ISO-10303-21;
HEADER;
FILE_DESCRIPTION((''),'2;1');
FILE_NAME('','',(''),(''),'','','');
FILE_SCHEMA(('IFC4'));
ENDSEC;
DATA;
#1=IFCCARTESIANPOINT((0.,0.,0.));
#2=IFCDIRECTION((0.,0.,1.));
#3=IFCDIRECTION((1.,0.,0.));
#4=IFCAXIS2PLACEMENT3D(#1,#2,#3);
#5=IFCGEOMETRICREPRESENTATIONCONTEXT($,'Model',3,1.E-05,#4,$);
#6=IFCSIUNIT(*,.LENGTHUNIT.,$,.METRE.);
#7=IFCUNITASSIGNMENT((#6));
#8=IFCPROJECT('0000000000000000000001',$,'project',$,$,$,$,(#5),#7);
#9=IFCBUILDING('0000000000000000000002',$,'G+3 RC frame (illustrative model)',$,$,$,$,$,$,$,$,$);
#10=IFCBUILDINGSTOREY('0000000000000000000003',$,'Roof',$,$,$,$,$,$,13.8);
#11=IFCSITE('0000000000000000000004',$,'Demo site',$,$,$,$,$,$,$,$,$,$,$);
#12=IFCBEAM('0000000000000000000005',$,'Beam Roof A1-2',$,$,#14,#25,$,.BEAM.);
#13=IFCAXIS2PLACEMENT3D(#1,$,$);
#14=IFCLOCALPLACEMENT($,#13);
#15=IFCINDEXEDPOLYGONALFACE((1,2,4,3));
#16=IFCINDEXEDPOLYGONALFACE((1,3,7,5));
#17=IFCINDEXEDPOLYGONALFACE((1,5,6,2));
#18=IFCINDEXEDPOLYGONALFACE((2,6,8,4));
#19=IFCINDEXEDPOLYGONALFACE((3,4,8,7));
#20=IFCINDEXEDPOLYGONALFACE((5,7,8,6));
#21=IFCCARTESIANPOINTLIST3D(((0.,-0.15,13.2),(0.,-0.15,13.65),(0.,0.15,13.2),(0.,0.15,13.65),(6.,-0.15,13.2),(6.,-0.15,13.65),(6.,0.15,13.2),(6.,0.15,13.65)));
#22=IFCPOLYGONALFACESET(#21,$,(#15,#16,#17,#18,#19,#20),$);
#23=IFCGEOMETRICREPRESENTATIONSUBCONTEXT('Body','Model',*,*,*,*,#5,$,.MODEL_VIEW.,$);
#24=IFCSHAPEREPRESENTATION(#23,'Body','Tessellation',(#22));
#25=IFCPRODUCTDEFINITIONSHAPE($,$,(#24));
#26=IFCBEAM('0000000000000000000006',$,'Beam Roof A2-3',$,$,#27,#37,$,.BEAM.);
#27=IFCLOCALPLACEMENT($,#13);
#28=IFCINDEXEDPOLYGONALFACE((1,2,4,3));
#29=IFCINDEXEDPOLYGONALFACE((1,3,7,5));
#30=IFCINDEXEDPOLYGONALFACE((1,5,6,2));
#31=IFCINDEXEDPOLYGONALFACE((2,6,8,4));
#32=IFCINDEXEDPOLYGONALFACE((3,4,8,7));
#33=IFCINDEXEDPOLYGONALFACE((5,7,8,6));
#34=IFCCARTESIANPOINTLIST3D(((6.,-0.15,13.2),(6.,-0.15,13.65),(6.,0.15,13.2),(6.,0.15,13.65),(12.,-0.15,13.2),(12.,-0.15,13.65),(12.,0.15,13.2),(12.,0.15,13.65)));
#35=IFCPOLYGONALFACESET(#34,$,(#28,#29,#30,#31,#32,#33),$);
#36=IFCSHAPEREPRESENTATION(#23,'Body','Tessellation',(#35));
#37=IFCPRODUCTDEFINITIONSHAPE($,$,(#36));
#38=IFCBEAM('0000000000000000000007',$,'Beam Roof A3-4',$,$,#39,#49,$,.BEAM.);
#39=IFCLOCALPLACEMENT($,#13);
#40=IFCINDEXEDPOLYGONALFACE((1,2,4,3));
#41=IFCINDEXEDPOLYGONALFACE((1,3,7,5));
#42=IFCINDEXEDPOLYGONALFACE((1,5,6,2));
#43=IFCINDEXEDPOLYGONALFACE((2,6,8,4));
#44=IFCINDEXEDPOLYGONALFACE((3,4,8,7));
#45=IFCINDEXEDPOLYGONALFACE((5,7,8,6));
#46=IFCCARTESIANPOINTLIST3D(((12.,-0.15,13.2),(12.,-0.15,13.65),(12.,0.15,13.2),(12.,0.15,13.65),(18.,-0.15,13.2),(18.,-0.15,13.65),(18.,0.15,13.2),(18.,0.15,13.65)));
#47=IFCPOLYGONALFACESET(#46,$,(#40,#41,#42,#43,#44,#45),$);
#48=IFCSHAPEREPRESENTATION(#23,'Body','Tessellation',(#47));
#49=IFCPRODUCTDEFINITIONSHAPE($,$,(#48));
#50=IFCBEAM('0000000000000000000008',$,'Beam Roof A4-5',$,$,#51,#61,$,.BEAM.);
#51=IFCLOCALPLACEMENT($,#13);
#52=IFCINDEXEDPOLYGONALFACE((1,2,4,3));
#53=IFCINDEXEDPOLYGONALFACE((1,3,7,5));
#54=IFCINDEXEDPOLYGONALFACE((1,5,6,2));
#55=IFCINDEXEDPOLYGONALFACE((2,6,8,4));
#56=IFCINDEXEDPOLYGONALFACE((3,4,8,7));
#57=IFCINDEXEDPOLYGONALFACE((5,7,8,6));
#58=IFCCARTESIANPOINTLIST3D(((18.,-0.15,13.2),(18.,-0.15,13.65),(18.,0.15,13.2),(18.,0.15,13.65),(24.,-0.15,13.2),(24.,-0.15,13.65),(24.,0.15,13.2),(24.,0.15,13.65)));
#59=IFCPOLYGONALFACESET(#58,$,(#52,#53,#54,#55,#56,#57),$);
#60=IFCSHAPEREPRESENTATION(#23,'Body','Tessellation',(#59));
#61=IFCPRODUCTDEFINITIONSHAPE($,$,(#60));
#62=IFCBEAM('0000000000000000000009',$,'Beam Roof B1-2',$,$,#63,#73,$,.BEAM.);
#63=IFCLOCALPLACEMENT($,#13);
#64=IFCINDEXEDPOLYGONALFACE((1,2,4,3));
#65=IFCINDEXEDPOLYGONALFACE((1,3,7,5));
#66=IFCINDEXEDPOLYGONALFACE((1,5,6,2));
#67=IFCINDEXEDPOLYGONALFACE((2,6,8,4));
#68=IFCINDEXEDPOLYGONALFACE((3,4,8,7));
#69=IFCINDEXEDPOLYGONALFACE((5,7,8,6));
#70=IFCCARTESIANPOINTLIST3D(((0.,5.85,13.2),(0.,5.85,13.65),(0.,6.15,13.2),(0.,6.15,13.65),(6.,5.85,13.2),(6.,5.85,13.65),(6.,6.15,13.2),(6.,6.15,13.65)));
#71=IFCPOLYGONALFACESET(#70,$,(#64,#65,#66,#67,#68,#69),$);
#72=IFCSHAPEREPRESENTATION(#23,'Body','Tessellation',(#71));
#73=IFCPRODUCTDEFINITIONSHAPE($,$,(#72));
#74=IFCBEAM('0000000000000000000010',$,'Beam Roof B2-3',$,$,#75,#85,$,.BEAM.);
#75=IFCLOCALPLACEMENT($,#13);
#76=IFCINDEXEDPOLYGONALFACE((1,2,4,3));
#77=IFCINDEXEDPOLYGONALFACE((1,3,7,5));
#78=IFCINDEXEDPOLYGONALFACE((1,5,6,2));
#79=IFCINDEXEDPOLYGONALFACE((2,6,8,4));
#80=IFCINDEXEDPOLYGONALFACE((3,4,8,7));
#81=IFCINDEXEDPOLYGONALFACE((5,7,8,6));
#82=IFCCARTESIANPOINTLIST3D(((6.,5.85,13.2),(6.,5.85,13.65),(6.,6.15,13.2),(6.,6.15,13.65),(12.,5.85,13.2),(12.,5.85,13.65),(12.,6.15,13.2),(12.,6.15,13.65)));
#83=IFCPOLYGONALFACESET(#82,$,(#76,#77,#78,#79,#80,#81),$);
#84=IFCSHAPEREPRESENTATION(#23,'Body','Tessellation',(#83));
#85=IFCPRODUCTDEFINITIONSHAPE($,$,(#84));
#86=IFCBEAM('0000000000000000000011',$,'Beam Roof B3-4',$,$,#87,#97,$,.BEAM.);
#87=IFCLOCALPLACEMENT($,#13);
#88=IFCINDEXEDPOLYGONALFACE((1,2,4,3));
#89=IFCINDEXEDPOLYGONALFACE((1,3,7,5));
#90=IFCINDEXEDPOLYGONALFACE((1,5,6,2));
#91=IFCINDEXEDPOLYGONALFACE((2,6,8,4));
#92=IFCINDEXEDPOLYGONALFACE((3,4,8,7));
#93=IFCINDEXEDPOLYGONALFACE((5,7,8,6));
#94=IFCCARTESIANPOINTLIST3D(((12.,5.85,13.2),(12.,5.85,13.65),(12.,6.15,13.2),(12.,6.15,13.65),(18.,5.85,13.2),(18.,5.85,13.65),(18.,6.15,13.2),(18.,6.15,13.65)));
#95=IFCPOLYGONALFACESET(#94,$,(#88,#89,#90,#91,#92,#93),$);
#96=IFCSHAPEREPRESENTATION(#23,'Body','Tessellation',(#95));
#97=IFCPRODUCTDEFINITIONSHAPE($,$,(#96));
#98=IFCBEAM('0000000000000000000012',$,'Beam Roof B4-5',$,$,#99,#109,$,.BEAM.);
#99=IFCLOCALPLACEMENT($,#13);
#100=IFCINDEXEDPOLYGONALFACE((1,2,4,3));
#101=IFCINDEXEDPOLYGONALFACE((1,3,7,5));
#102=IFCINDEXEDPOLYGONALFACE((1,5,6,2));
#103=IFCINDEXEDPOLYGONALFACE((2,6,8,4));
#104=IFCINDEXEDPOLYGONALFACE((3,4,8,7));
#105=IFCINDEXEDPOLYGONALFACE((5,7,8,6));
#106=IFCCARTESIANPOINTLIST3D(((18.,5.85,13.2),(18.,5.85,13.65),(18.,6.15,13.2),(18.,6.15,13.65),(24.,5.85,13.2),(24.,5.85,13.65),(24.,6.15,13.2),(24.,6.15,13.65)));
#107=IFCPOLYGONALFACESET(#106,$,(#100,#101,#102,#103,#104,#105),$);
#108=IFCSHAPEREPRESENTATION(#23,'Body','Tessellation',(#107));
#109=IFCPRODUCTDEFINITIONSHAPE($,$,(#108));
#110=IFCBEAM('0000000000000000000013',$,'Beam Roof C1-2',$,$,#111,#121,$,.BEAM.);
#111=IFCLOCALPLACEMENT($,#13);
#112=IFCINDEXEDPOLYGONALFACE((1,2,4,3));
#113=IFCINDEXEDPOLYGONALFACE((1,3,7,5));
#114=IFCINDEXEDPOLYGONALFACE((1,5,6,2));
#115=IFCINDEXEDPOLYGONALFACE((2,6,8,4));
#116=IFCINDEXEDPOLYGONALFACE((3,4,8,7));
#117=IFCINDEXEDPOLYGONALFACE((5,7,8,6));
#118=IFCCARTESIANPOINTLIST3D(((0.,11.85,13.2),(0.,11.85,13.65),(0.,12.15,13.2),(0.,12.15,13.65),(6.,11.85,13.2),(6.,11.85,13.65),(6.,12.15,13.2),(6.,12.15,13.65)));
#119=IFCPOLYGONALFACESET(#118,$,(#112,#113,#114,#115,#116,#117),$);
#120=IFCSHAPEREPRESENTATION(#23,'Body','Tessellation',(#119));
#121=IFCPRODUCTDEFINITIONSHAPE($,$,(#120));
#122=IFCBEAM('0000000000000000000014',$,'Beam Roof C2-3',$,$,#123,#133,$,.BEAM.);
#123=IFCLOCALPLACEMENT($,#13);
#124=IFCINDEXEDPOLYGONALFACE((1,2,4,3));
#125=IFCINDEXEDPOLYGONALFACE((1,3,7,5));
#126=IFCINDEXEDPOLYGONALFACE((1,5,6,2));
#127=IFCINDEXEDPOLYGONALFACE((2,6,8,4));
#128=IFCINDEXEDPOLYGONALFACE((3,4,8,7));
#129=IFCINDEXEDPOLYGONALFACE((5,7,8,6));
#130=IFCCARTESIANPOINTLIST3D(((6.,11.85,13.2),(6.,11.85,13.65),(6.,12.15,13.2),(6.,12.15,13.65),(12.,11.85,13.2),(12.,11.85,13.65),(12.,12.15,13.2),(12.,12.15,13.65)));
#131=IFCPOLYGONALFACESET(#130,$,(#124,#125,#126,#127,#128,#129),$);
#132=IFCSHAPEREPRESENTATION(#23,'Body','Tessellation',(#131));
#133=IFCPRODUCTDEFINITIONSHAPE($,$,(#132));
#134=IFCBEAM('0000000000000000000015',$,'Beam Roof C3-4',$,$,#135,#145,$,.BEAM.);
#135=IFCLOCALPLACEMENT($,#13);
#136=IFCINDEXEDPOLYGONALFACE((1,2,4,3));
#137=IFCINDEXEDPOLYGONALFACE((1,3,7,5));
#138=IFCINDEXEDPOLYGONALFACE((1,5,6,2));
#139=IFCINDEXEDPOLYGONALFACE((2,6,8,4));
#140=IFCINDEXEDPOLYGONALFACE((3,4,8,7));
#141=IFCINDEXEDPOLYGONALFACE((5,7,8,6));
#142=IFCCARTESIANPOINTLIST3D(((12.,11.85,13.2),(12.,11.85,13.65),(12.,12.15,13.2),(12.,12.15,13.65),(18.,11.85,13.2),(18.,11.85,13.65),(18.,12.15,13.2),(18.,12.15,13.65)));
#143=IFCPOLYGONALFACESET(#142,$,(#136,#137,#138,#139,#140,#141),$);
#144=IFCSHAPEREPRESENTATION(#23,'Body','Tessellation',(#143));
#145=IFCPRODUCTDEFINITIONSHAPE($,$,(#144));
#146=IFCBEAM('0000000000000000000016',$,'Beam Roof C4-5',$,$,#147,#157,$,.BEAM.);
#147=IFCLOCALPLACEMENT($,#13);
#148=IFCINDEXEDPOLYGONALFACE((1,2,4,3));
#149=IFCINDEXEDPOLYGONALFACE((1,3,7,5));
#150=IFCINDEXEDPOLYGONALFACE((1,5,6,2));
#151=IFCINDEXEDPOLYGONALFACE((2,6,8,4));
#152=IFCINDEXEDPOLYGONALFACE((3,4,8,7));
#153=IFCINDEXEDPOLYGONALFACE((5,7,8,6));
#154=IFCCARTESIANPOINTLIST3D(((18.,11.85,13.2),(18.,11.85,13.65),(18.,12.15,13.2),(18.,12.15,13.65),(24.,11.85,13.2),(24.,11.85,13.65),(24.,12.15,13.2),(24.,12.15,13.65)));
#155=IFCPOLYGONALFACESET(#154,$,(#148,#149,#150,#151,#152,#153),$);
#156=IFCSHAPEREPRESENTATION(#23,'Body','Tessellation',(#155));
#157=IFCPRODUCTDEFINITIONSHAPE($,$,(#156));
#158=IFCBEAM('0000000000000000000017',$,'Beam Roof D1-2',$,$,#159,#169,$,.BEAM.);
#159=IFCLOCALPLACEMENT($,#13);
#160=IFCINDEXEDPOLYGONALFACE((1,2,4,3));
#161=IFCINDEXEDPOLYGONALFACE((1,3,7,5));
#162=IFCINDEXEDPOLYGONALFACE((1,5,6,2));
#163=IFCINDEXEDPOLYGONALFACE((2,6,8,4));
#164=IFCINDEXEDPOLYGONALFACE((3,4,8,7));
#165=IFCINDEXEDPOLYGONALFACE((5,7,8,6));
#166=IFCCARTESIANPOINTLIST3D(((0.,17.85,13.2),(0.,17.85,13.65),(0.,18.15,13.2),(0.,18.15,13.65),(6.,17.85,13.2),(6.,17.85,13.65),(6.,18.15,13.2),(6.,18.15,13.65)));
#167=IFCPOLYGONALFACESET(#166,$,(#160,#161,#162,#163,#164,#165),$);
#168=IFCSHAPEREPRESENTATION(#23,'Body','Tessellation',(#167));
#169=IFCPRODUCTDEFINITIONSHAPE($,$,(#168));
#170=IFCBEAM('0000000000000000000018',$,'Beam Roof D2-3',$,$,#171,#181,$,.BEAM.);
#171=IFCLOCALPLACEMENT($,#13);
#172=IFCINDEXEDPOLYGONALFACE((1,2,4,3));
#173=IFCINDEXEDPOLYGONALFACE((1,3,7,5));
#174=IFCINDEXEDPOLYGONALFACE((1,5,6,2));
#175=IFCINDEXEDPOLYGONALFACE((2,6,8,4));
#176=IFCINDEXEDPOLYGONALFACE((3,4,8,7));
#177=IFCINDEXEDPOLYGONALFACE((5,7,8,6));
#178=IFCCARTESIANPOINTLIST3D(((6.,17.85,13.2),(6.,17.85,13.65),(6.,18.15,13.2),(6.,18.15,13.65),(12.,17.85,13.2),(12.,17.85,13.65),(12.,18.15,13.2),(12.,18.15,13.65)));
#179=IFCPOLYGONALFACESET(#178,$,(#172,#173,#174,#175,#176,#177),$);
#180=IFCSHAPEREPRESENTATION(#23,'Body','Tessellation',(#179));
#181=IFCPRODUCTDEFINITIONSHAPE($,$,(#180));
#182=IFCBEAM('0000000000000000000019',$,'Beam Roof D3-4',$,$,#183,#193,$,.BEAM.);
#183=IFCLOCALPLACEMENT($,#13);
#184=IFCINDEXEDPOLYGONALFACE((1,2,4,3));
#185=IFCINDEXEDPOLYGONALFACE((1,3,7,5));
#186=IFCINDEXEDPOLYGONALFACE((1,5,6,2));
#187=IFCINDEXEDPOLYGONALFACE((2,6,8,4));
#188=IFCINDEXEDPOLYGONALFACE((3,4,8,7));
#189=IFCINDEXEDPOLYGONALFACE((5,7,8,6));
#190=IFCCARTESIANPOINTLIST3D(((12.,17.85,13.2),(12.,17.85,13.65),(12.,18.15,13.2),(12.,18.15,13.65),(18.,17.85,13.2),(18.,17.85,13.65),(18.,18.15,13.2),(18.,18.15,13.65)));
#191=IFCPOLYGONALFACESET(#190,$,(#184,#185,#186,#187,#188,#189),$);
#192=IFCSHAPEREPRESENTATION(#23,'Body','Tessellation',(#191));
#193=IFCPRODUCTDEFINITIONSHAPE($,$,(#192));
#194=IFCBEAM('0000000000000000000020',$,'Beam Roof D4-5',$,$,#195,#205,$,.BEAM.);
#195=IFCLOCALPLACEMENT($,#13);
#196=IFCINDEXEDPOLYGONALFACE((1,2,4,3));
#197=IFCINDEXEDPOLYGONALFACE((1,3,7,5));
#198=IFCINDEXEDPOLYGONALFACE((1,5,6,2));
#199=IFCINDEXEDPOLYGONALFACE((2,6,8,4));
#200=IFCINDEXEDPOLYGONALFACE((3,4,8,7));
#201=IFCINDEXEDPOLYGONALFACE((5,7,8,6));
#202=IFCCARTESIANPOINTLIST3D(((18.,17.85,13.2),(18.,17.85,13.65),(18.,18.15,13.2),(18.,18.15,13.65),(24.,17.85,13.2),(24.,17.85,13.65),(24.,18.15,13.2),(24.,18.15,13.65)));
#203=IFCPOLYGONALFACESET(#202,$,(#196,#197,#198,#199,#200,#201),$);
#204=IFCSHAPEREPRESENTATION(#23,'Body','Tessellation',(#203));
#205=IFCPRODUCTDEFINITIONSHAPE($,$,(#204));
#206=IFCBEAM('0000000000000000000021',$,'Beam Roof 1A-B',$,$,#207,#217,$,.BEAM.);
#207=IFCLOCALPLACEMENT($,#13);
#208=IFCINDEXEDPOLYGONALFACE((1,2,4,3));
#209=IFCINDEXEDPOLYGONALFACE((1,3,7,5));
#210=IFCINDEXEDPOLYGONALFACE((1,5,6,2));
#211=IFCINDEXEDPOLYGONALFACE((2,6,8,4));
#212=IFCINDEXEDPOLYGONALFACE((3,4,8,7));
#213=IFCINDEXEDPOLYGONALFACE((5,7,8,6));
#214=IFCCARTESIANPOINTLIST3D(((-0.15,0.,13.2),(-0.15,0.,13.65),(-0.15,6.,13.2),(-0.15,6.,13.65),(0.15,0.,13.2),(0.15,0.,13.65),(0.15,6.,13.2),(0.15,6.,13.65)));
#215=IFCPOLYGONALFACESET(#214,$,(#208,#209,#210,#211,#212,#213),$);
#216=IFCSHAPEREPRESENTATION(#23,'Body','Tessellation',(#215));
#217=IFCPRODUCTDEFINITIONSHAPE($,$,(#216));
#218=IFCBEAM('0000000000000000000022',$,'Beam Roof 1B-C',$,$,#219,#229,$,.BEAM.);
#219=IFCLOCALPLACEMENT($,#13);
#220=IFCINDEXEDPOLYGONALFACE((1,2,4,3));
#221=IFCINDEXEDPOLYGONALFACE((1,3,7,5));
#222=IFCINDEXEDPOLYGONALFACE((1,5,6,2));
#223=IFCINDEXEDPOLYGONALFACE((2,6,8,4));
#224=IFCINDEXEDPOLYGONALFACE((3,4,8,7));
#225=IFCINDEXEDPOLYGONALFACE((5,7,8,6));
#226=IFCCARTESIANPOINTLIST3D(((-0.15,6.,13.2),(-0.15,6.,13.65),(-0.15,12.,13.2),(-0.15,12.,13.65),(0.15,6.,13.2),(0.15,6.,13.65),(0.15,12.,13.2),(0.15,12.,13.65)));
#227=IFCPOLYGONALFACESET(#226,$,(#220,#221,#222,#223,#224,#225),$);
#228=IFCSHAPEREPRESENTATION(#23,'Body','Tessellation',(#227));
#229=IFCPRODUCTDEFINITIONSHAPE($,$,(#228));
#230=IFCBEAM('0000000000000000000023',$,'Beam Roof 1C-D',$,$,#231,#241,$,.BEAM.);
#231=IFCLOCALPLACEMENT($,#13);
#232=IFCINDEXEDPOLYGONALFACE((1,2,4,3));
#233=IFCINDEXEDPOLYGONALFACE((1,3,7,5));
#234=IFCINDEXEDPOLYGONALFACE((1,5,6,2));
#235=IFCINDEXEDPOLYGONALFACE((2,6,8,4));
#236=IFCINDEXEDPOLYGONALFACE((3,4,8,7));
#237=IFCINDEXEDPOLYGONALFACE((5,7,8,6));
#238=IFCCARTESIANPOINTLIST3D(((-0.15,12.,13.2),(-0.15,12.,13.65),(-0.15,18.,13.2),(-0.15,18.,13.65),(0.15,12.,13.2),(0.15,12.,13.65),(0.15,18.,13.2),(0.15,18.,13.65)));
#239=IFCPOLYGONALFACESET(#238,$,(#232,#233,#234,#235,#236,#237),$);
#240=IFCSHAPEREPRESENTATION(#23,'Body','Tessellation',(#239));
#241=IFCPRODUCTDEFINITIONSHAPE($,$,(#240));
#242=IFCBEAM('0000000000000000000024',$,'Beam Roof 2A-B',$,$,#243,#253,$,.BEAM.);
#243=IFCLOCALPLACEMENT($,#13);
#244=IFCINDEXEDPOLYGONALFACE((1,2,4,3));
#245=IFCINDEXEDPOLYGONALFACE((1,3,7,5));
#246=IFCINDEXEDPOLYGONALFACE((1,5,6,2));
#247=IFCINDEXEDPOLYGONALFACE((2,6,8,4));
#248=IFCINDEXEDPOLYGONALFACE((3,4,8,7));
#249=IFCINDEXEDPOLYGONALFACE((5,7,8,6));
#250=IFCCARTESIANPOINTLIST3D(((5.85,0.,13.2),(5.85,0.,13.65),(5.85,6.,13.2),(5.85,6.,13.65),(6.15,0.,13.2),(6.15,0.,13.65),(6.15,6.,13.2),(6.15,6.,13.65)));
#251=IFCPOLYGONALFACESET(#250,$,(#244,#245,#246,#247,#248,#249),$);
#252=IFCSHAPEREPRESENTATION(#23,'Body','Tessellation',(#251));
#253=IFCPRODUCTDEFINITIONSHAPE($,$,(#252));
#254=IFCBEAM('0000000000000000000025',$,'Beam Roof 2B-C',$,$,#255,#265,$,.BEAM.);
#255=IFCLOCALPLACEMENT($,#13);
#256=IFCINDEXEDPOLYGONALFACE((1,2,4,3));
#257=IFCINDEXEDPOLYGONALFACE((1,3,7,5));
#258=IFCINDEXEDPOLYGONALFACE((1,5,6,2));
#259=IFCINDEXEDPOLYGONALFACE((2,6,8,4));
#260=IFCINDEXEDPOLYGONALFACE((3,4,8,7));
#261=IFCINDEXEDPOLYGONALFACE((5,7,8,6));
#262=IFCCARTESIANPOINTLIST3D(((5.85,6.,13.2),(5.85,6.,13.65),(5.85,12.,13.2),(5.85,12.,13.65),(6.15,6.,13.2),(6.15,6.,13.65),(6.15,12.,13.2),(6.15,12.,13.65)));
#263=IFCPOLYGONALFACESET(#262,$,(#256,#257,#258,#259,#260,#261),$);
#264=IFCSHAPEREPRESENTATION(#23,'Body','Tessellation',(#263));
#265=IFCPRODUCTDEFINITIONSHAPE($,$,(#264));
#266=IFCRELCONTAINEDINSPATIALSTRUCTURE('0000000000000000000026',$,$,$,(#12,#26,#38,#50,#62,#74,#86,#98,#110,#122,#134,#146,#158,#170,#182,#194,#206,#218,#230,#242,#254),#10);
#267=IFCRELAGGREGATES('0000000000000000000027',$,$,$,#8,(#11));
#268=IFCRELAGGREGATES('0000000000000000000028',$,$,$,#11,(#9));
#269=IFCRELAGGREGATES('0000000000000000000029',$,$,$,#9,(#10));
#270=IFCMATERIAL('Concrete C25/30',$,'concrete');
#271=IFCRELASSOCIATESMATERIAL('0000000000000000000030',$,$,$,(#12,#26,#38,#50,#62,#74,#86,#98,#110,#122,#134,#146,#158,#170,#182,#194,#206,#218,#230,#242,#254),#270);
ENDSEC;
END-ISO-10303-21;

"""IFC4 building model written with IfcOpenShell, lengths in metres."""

from ifc_helpers import new_model, si_unit, frame, frame_2d, origin, origin_with_axes, place, context, subcontext, project, spatial, rectangle, extrude, material, element, save


model = new_model("IFC4")

# Units and contexts
model_context = context("Model", 3, precision=1e-05, world=origin_with_axes())
body_context = subcontext(model_context, "Body", "Model", "MODEL_VIEW")
ifc_project = project(units=[si_unit("LENGTHUNIT", "METRE")], contexts=[model_context])

# Site, building, storey
site = spatial("IfcSite", under=ifc_project, Name="Demo site")
building = spatial("IfcBuilding", under=site, Name="G+3 RC frame (illustrative model)")
storey = spatial("IfcBuildingStorey", under=building, Name="Roof", Elevation=13.8)

# Beams
ifc_material_1 = material(Name="Concrete C25/30", Category="concrete")
for number, where, z_axis, x_axis, name in (
    (1, (0.0, -0.15, 13.2), (0.0, 0.0, 1.0), (1.0, 0.0, 0.0), "Beam Roof A1-2"),
    (2, (6.0, -0.15, 13.2), (0.0, 0.0, 1.0), (1.0, 0.0, 0.0), "Beam Roof A2-3"),
    (3, (12.0, -0.15, 13.2), (0.0, 0.0, 1.0), (1.0, 0.0, 0.0), "Beam Roof A3-4"),
    (4, (18.0, -0.15, 13.2), (0.0, 0.0, 1.0), (1.0, 0.0, 0.0), "Beam Roof A4-5"),
    (5, (0.0, 5.85, 13.2), (0.0, 0.0, 1.0), (1.0, 0.0, 0.0), "Beam Roof B1-2"),
    (6, (6.0, 5.85, 13.2), (0.0, 0.0, 1.0), (1.0, 0.0, 0.0), "Beam Roof B2-3"),
    (7, (12.0, 5.85, 13.2), (0.0, 0.0, 1.0), (1.0, 0.0, 0.0), "Beam Roof B3-4"),
    (8, (18.0, 5.85, 13.2), (0.0, 0.0, 1.0), (1.0, 0.0, 0.0), "Beam Roof B4-5"),
    (9, (0.0, 11.85, 13.2), (0.0, 0.0, 1.0), (1.0, 0.0, 0.0), "Beam Roof C1-2"),
    (10, (6.0, 11.85, 13.2), (0.0, 0.0, 1.0), (1.0, 0.0, 0.0), "Beam Roof C2-3"),
    (11, (12.0, 11.85, 13.2), (0.0, 0.0, 1.0), (1.0, 0.0, 0.0), "Beam Roof C3-4"),
    (12, (18.0, 11.85, 13.2), (0.0, 0.0, 1.0), (1.0, 0.0, 0.0), "Beam Roof C4-5"),
    (13, (0.0, 17.85, 13.2), (0.0, 0.0, 1.0), (1.0, 0.0, 0.0), "Beam Roof D1-2"),
    (14, (6.0, 17.85, 13.2), (0.0, 0.0, 1.0), (1.0, 0.0, 0.0), "Beam Roof D2-3"),
    (15, (12.0, 17.85, 13.2), (0.0, 0.0, 1.0), (1.0, 0.0, 0.0), "Beam Roof D3-4"),
    (16, (18.0, 17.85, 13.2), (0.0, 0.0, 1.0), (1.0, 0.0, 0.0), "Beam Roof D4-5"),
):
    element("IfcBeam", number, at=place(None, frame(where, z_axis=z_axis, x_axis=x_axis)), inside=storey, material=ifc_material_1, Name=name, PredefinedType="BEAM", context=body_context, shape_type="SweptSolid", body=[
        extrude(rectangle(XDim=6.0, YDim=0.3, at=frame_2d((3.0, 0.15))), origin(), (0.0, 0.0, 1.0), 0.45),
    ])
for number, where, z_axis, x_axis, name in (
    (17, (-0.15, 0.0, 13.2), (0.0, 0.0, 1.0), (1.0, 0.0, 0.0), "Beam Roof 1A-B"),
    (18, (-0.15, 6.0, 13.2), (0.0, 0.0, 1.0), (1.0, 0.0, 0.0), "Beam Roof 1B-C"),
    (19, (-0.15, 12.0, 13.2), (0.0, 0.0, 1.0), (1.0, 0.0, 0.0), "Beam Roof 1C-D"),
    (20, (5.85, 0.0, 13.2), (0.0, 0.0, 1.0), (1.0, 0.0, 0.0), "Beam Roof 2A-B"),
    (21, (5.85, 6.0, 13.2), (0.0, 0.0, 1.0), (1.0, 0.0, 0.0), "Beam Roof 2B-C"),
):
    element("IfcBeam", number, at=place(None, frame(where, z_axis=z_axis, x_axis=x_axis)), inside=storey, material=ifc_material_1, Name=name, PredefinedType="BEAM", context=body_context, shape_type="SweptSolid", body=[
        extrude(rectangle(XDim=0.3, YDim=6.0, at=frame_2d((0.15, 3.0))), origin(), (0.0, 0.0, 1.0), 0.45),
    ])

save(model, "model.ifc")
